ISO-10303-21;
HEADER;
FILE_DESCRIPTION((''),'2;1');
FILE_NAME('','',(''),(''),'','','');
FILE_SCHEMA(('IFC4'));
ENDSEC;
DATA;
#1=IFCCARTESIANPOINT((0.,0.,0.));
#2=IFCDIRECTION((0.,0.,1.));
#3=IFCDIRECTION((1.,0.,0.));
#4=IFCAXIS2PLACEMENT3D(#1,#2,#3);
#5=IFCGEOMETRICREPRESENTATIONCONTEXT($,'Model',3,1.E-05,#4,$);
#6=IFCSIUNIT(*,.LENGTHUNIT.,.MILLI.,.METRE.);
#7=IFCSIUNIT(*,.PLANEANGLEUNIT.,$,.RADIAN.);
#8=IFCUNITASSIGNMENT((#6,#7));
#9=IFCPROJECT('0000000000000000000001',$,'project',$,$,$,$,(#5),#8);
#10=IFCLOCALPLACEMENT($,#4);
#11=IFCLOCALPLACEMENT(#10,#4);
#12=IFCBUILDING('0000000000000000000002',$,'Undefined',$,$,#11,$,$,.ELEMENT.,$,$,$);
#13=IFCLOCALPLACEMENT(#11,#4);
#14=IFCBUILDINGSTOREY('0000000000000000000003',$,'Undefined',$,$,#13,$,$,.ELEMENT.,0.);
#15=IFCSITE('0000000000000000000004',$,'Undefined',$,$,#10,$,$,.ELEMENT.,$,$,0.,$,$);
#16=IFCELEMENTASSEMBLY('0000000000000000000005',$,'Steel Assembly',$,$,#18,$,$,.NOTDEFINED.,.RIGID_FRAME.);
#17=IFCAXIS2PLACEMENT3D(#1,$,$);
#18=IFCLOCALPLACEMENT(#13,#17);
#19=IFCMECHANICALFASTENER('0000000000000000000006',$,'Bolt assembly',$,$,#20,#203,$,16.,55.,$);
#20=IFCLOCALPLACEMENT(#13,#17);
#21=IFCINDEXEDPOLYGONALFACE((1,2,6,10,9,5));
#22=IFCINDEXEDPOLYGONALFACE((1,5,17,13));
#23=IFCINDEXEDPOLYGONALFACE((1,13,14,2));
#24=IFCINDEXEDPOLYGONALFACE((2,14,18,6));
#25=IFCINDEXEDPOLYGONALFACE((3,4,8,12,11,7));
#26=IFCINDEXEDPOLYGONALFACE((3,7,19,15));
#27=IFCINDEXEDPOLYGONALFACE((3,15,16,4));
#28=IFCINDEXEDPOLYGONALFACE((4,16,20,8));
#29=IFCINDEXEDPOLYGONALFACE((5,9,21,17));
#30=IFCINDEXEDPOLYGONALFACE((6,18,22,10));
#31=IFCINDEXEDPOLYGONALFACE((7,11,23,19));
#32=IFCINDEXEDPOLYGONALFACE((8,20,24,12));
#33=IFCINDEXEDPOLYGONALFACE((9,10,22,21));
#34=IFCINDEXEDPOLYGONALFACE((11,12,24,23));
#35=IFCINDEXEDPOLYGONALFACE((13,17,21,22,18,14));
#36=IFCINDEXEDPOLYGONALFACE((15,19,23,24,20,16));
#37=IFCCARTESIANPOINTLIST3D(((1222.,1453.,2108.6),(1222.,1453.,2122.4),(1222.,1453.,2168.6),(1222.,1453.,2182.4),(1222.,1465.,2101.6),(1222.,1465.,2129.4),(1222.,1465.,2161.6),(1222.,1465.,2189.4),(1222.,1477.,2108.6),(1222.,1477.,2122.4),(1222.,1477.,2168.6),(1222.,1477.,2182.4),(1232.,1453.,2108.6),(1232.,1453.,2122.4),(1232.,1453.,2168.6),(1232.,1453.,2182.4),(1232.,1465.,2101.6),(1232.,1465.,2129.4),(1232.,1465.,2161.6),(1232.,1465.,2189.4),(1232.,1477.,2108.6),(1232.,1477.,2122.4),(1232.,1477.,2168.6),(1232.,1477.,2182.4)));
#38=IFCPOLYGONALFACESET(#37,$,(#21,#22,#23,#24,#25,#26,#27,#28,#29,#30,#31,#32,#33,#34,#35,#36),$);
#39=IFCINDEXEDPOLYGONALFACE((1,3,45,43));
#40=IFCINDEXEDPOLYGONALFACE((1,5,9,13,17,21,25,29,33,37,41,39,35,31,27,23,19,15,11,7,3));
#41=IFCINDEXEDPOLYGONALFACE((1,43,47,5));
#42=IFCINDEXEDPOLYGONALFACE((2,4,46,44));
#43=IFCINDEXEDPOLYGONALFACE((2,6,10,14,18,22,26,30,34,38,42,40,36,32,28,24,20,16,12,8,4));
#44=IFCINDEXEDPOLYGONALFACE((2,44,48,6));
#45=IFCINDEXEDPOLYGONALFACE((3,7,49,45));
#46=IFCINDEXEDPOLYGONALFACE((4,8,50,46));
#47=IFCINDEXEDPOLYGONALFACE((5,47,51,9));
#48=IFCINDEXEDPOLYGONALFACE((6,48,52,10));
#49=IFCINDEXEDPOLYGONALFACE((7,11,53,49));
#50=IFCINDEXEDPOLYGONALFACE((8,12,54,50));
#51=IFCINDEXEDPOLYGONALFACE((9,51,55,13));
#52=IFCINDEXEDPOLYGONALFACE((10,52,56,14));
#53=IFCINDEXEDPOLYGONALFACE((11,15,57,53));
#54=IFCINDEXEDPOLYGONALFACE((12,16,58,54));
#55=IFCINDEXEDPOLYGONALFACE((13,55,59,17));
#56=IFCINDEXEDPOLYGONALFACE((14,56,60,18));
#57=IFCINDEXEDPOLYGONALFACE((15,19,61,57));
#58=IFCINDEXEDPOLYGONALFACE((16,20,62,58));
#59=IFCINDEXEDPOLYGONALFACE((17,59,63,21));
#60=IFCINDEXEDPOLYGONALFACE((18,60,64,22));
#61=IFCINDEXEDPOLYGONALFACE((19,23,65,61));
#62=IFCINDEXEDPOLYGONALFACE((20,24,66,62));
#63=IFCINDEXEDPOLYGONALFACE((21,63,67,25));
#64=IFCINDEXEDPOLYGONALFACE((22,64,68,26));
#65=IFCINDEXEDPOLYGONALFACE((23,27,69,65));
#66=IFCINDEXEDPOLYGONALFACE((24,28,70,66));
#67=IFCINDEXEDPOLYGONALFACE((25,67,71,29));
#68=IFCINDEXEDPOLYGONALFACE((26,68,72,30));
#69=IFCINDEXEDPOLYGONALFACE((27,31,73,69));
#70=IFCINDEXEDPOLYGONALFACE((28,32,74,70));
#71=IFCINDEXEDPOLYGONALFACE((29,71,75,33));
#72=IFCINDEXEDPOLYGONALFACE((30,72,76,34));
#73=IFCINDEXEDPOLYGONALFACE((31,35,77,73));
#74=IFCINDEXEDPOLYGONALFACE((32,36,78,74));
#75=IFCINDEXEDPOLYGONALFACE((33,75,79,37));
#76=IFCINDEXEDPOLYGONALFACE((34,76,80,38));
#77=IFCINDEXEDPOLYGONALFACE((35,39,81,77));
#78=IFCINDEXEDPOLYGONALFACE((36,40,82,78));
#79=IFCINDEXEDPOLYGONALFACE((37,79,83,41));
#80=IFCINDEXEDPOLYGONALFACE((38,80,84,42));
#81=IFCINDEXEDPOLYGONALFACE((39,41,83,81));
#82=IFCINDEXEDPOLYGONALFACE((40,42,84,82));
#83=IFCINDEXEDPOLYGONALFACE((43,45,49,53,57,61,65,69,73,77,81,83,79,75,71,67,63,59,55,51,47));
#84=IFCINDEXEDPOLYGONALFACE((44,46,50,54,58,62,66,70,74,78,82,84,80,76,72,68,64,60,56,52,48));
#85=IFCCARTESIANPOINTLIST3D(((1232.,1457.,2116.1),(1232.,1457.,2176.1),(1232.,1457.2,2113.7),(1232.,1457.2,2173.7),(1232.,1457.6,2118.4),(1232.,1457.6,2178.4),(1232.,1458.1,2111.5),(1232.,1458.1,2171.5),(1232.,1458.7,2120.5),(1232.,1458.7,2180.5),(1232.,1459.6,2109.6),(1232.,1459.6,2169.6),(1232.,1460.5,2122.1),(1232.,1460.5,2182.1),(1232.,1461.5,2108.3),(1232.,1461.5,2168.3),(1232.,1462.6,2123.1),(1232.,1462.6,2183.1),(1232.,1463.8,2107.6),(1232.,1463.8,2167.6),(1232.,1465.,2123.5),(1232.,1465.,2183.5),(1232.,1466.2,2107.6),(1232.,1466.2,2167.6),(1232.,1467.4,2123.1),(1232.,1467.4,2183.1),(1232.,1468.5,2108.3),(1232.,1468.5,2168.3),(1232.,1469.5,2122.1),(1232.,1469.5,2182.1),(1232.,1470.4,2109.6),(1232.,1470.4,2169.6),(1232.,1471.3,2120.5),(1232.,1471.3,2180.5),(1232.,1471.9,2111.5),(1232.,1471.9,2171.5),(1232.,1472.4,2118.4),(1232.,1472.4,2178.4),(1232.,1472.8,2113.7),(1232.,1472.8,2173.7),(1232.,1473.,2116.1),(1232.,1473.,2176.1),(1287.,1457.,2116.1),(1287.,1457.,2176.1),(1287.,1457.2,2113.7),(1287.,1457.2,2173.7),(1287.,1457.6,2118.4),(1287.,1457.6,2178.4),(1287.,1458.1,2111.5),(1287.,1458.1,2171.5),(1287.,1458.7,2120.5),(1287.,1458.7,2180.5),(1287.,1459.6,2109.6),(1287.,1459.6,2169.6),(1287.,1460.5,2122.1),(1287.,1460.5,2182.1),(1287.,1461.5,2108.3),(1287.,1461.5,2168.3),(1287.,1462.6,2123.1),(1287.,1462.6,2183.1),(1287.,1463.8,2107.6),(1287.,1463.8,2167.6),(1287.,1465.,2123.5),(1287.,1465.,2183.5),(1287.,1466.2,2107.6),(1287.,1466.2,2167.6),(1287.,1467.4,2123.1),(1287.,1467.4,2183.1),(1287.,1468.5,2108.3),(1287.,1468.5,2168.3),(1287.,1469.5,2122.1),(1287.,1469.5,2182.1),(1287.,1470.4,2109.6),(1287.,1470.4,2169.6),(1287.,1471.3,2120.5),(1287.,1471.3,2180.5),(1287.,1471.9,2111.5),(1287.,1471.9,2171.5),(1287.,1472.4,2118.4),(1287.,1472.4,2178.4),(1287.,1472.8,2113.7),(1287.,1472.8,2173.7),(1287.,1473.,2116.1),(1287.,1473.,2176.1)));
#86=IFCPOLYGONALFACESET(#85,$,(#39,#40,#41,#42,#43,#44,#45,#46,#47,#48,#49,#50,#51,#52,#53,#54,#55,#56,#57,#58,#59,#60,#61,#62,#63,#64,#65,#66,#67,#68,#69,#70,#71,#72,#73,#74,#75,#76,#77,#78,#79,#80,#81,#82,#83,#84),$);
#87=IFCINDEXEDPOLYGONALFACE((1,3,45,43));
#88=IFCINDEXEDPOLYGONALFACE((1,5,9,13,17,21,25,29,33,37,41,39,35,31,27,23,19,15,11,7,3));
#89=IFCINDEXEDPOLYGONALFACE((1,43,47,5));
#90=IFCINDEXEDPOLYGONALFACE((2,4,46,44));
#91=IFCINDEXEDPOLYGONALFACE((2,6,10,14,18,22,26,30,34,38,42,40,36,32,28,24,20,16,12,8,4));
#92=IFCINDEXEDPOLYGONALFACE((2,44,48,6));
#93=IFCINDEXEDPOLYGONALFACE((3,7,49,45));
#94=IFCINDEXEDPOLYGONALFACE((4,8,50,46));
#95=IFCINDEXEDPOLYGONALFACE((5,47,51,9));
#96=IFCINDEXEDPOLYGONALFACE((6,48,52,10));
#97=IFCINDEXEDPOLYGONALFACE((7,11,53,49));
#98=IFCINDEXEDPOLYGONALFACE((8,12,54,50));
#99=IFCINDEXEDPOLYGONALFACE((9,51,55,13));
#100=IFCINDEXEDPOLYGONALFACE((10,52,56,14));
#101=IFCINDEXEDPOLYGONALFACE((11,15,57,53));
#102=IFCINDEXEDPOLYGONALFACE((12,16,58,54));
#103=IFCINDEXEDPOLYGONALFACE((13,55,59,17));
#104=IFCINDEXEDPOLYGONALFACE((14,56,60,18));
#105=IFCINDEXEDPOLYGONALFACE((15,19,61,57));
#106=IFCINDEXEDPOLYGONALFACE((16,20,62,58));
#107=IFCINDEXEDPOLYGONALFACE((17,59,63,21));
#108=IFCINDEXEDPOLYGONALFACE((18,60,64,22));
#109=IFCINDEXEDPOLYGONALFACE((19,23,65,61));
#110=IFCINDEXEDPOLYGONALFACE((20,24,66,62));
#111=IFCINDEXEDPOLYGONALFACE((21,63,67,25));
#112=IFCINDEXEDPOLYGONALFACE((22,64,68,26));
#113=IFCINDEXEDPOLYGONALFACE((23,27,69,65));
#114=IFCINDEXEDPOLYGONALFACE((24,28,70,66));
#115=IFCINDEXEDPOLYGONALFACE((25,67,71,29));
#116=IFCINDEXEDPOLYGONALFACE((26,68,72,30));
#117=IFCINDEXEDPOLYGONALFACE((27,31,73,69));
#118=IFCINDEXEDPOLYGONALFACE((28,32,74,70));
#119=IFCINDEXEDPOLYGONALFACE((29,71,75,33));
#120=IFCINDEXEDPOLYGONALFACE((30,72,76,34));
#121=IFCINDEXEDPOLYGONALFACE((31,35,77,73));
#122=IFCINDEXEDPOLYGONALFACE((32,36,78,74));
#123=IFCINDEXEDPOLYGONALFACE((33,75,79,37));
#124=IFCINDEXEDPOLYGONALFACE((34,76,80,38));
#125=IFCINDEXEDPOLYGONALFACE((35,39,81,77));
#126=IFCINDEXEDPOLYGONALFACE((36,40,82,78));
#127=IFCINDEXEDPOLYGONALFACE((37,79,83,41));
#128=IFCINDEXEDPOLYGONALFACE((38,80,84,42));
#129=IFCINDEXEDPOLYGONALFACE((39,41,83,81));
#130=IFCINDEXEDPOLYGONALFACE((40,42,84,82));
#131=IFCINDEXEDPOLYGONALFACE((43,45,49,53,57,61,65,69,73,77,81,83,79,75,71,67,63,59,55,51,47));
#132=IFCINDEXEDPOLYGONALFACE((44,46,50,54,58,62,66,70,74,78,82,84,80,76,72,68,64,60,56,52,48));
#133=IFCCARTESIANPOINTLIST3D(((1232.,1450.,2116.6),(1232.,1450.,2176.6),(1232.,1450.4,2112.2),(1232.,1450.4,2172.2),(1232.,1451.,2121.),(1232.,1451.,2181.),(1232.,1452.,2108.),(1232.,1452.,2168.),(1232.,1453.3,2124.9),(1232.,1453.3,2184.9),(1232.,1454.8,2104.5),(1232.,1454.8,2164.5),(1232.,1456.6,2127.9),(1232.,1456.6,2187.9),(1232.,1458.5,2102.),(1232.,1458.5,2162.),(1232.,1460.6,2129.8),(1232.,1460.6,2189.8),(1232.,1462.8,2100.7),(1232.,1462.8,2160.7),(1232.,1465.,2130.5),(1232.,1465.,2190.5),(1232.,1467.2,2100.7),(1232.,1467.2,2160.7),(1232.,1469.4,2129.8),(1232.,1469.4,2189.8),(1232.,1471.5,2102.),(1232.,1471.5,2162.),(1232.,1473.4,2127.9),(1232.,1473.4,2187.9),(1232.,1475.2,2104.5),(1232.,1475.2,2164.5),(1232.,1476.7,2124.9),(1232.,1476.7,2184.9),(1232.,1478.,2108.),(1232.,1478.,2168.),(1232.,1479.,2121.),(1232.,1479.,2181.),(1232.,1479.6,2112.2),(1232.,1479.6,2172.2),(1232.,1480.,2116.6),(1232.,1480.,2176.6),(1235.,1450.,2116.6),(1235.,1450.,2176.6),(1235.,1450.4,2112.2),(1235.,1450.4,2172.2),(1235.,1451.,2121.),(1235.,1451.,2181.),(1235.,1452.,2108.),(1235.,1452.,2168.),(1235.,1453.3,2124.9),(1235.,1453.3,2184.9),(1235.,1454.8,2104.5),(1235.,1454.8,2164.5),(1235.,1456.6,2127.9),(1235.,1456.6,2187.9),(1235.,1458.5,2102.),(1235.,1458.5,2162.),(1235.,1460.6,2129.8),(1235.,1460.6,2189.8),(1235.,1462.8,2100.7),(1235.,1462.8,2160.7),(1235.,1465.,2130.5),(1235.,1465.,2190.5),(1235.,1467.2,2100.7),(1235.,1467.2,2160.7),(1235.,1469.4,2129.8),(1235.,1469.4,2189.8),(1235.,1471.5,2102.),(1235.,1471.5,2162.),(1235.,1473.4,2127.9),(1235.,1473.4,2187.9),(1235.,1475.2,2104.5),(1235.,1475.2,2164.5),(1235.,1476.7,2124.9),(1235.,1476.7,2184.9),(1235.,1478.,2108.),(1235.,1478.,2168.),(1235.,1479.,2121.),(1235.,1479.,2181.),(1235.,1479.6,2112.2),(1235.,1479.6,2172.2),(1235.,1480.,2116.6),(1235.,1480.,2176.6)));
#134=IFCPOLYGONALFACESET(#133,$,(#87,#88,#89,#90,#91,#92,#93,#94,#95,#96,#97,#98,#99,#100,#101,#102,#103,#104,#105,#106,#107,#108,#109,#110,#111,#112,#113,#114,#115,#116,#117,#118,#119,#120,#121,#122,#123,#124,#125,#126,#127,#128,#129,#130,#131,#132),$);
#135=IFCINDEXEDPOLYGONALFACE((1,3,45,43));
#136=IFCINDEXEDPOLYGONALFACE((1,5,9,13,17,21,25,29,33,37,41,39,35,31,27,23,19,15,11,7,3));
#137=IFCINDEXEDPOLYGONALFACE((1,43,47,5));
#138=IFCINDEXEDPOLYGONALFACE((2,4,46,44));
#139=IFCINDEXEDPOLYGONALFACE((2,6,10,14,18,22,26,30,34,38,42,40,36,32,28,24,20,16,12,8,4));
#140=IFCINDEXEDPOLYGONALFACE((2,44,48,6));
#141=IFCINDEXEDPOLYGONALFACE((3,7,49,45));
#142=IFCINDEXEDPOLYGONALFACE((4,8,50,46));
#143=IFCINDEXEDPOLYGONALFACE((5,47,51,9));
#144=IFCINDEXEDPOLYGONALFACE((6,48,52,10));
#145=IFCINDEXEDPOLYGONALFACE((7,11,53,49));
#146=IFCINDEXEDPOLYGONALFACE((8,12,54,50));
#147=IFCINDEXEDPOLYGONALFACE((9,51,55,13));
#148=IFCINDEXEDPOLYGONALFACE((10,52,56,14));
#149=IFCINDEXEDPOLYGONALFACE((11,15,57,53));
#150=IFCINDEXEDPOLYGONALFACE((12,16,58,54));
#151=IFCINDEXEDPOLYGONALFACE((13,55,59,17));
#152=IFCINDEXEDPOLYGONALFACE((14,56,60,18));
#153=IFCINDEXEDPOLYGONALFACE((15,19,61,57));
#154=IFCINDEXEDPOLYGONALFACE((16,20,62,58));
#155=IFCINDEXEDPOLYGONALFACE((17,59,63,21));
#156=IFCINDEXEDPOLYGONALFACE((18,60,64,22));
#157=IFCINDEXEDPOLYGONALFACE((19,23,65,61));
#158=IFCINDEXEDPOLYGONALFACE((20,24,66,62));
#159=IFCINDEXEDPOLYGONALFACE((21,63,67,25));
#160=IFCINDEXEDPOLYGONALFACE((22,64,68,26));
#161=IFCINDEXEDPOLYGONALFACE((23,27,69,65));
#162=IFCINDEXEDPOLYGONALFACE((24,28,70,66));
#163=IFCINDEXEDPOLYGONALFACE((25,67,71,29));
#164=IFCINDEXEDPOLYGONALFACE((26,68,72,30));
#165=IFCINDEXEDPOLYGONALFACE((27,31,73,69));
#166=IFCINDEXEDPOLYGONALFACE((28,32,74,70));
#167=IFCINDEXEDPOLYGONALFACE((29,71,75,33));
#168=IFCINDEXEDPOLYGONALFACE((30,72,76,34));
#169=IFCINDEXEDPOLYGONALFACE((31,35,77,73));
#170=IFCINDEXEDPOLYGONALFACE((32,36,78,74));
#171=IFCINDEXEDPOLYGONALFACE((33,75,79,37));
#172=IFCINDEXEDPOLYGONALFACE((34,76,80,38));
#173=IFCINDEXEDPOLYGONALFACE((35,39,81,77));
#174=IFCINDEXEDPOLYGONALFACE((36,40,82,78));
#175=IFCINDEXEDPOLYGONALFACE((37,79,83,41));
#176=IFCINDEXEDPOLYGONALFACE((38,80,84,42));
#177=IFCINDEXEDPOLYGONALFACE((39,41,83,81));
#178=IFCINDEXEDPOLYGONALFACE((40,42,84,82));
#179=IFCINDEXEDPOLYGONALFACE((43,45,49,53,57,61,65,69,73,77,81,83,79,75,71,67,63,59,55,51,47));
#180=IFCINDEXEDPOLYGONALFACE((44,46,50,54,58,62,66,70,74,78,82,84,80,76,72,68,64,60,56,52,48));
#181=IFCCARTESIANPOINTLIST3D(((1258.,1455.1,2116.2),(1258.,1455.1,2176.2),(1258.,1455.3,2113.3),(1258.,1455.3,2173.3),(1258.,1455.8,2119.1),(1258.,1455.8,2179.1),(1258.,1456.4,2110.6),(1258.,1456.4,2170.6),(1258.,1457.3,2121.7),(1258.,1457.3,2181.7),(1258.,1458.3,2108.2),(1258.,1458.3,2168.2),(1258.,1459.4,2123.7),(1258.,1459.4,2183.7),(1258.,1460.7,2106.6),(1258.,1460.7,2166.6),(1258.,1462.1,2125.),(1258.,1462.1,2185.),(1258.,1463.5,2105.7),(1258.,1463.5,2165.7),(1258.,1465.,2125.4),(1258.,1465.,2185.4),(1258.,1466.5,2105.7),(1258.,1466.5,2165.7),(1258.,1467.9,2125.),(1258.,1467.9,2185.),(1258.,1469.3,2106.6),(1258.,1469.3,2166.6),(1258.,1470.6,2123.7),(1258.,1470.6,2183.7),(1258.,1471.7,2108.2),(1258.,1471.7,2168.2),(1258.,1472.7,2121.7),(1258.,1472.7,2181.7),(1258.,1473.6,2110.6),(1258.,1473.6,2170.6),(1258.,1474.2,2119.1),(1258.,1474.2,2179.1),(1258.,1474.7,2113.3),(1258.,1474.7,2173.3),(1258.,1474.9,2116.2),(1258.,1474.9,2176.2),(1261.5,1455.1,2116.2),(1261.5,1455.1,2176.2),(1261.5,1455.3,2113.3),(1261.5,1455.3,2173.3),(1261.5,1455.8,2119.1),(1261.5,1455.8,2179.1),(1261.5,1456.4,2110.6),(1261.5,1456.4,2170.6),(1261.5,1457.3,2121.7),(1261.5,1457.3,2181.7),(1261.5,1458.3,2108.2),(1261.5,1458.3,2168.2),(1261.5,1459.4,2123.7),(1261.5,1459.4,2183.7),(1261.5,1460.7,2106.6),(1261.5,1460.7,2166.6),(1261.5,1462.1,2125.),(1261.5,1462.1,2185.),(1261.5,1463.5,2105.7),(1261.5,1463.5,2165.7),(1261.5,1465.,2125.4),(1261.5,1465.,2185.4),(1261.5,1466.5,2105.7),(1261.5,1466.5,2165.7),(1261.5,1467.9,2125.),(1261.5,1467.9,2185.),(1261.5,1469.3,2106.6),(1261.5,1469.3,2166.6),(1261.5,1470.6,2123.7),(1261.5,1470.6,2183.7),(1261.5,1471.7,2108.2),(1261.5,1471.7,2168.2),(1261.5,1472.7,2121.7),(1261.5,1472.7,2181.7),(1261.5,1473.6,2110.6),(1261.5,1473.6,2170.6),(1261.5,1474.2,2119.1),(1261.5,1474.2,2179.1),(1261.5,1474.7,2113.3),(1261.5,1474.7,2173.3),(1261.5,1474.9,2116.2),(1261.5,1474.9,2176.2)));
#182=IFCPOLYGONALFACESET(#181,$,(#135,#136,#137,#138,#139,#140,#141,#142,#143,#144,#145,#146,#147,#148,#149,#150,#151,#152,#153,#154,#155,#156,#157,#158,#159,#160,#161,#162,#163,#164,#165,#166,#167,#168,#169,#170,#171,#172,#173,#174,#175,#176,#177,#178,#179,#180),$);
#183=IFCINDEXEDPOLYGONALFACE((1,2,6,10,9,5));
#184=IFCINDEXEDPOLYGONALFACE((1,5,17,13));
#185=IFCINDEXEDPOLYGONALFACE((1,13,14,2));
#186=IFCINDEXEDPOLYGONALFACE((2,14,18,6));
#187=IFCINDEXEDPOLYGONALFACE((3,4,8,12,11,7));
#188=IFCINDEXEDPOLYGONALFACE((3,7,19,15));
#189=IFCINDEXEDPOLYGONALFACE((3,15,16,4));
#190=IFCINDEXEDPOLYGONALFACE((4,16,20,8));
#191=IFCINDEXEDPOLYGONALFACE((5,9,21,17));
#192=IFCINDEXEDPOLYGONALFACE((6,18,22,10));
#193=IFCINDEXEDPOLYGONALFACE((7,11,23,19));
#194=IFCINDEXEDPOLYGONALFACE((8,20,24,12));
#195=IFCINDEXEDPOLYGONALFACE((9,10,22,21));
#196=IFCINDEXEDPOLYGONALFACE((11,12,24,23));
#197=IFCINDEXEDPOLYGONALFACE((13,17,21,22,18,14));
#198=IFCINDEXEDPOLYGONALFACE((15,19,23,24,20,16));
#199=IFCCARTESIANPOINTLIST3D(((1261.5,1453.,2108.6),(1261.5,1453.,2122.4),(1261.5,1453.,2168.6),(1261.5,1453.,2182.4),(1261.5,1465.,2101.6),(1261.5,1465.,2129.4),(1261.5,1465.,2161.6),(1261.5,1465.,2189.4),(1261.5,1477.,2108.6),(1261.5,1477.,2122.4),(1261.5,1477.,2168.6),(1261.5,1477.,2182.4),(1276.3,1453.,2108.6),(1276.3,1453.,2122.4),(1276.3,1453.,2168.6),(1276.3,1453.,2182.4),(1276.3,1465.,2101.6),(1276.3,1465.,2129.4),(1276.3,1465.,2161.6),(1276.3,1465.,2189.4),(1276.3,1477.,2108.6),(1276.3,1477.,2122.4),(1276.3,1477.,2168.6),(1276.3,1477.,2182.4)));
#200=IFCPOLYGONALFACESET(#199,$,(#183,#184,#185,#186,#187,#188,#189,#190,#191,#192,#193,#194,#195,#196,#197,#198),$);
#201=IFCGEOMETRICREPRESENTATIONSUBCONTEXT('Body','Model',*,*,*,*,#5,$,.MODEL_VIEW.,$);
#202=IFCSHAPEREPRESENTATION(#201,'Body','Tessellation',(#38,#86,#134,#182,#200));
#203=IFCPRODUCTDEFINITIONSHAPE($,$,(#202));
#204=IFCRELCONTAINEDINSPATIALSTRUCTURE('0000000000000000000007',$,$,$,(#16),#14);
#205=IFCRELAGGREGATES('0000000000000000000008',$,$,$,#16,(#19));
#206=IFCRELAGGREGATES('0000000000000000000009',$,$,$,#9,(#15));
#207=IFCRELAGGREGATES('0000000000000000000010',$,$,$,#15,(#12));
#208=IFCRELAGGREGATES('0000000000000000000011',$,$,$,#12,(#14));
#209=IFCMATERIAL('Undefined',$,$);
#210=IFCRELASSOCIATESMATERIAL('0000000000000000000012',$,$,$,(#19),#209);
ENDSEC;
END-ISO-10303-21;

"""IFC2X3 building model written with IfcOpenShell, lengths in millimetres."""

from ifc_helpers import new_model, si_unit, frame, origin_with_axes, origin_2d_with_axis, place, context, subcontext, project, spatial, polyline, circle, outline, extrude, source, transform, mapped, material, element, aggregate, save


model = new_model("IFC2X3")

# Units and contexts
model_context = context("Model", 3, precision=1e-05, world=origin_with_axes())
body_context = subcontext(model_context, "Body", "Model", "MODEL_VIEW")
ifc_project = project(units=[si_unit("LENGTHUNIT", "METRE", prefix="MILLI"), si_unit("PLANEANGLEUNIT", "RADIAN")], contexts=[model_context])

# Site, building, storey
site_placement = place(None, origin_with_axes())
site = spatial("IfcSite", under=ifc_project, at=site_placement, Name="Undefined", CompositionType="ELEMENT", RefElevation=0.0)
building_placement = place(site_placement, origin_with_axes())
building = spatial("IfcBuilding", under=site, at=building_placement, Name="Undefined", CompositionType="ELEMENT")
storey_placement = place(building_placement, origin_with_axes())
storey = spatial("IfcBuildingStorey", under=building, at=storey_placement, Name="Undefined", CompositionType="ELEMENT", Elevation=0.0)

# Shared definitions
ifc_material_1 = material(Name="Undefined")

# Element assembly, mechanical fastener
assembly_1_placement = place(storey_placement, origin_with_axes())
assembly_1 = element("IfcElementAssembly", 1, at=assembly_1_placement, inside=storey, Name="Steel Assembly", AssemblyPlace="NOTDEFINED", PredefinedType="RIGID_FRAME")
shared_shape_1 = source(origin_with_axes(), body_context, "Body", "SweptSolid", [
    extrude(outline(polyline([(13.9, 0.0), (6.9, 12.0), (-6.9, 12.0), (-13.9, 0.0), (-6.9, -12.0), (6.9, -12.0), (13.9, 0.0)])), frame((0.0, -30.0, 0.0), z_axis=(0.0, 1.0, 0.0), x_axis=(1.0, 0.0, 0.0)), (0.0, 0.0, 1.0), 10.0),
    extrude(circle(Radius=8.0, at=origin_2d_with_axis()), frame((0.0, -20.0, 0.0), z_axis=(0.0, 1.0, 0.0), x_axis=(1.0, 0.0, 0.0)), (0.0, 0.0, 1.0), 55.0),
    extrude(circle(Radius=15.0, at=origin_2d_with_axis()), frame((0.0, -20.0, 0.0), z_axis=(0.0, 1.0, 0.0), x_axis=(1.0, 0.0, 0.0)), (0.0, 0.0, 1.0), 3.0),
    extrude(circle(Radius=9.9, at=origin_2d_with_axis()), frame((0.0, 6.0, 0.0), z_axis=(0.0, 1.0, 0.0), x_axis=(1.0, 0.0, 0.0)), (0.0, 0.0, 1.0), 3.5),
    extrude(outline(polyline([(13.9, 0.0), (6.9, 12.0), (-6.9, 12.0), (-13.9, 0.0), (-6.9, -12.0), (6.9, -12.0), (13.9, 0.0)])), frame((0.0, 9.5, 0.0), z_axis=(0.0, 1.0, 0.0), x_axis=(1.0, 0.0, 0.0)), (0.0, 0.0, 1.0), 14.8),
])
mechanical_fastener_1_placement = place(assembly_1_placement, frame((1252.0, 1465.0, 2115.5), z_axis=(0.0, 1.0, 0.0), x_axis=(0.0, 0.0, 1.0)))
mechanical_fastener_1 = element("IfcMechanicalFastener", 2, at=mechanical_fastener_1_placement, material=ifc_material_1, Name="Bolt assembly", NominalDiameter=16.0, NominalLength=55.0, context=body_context, shape_type="MappedRepresentation", body=[
    mapped(shared_shape_1, transform((0.0, 0.0, 0.0))),
    mapped(shared_shape_1, transform((60.0, 0.0, 0.0))),
])

aggregate(assembly_1, [mechanical_fastener_1])

save(model, "model.ifc")
